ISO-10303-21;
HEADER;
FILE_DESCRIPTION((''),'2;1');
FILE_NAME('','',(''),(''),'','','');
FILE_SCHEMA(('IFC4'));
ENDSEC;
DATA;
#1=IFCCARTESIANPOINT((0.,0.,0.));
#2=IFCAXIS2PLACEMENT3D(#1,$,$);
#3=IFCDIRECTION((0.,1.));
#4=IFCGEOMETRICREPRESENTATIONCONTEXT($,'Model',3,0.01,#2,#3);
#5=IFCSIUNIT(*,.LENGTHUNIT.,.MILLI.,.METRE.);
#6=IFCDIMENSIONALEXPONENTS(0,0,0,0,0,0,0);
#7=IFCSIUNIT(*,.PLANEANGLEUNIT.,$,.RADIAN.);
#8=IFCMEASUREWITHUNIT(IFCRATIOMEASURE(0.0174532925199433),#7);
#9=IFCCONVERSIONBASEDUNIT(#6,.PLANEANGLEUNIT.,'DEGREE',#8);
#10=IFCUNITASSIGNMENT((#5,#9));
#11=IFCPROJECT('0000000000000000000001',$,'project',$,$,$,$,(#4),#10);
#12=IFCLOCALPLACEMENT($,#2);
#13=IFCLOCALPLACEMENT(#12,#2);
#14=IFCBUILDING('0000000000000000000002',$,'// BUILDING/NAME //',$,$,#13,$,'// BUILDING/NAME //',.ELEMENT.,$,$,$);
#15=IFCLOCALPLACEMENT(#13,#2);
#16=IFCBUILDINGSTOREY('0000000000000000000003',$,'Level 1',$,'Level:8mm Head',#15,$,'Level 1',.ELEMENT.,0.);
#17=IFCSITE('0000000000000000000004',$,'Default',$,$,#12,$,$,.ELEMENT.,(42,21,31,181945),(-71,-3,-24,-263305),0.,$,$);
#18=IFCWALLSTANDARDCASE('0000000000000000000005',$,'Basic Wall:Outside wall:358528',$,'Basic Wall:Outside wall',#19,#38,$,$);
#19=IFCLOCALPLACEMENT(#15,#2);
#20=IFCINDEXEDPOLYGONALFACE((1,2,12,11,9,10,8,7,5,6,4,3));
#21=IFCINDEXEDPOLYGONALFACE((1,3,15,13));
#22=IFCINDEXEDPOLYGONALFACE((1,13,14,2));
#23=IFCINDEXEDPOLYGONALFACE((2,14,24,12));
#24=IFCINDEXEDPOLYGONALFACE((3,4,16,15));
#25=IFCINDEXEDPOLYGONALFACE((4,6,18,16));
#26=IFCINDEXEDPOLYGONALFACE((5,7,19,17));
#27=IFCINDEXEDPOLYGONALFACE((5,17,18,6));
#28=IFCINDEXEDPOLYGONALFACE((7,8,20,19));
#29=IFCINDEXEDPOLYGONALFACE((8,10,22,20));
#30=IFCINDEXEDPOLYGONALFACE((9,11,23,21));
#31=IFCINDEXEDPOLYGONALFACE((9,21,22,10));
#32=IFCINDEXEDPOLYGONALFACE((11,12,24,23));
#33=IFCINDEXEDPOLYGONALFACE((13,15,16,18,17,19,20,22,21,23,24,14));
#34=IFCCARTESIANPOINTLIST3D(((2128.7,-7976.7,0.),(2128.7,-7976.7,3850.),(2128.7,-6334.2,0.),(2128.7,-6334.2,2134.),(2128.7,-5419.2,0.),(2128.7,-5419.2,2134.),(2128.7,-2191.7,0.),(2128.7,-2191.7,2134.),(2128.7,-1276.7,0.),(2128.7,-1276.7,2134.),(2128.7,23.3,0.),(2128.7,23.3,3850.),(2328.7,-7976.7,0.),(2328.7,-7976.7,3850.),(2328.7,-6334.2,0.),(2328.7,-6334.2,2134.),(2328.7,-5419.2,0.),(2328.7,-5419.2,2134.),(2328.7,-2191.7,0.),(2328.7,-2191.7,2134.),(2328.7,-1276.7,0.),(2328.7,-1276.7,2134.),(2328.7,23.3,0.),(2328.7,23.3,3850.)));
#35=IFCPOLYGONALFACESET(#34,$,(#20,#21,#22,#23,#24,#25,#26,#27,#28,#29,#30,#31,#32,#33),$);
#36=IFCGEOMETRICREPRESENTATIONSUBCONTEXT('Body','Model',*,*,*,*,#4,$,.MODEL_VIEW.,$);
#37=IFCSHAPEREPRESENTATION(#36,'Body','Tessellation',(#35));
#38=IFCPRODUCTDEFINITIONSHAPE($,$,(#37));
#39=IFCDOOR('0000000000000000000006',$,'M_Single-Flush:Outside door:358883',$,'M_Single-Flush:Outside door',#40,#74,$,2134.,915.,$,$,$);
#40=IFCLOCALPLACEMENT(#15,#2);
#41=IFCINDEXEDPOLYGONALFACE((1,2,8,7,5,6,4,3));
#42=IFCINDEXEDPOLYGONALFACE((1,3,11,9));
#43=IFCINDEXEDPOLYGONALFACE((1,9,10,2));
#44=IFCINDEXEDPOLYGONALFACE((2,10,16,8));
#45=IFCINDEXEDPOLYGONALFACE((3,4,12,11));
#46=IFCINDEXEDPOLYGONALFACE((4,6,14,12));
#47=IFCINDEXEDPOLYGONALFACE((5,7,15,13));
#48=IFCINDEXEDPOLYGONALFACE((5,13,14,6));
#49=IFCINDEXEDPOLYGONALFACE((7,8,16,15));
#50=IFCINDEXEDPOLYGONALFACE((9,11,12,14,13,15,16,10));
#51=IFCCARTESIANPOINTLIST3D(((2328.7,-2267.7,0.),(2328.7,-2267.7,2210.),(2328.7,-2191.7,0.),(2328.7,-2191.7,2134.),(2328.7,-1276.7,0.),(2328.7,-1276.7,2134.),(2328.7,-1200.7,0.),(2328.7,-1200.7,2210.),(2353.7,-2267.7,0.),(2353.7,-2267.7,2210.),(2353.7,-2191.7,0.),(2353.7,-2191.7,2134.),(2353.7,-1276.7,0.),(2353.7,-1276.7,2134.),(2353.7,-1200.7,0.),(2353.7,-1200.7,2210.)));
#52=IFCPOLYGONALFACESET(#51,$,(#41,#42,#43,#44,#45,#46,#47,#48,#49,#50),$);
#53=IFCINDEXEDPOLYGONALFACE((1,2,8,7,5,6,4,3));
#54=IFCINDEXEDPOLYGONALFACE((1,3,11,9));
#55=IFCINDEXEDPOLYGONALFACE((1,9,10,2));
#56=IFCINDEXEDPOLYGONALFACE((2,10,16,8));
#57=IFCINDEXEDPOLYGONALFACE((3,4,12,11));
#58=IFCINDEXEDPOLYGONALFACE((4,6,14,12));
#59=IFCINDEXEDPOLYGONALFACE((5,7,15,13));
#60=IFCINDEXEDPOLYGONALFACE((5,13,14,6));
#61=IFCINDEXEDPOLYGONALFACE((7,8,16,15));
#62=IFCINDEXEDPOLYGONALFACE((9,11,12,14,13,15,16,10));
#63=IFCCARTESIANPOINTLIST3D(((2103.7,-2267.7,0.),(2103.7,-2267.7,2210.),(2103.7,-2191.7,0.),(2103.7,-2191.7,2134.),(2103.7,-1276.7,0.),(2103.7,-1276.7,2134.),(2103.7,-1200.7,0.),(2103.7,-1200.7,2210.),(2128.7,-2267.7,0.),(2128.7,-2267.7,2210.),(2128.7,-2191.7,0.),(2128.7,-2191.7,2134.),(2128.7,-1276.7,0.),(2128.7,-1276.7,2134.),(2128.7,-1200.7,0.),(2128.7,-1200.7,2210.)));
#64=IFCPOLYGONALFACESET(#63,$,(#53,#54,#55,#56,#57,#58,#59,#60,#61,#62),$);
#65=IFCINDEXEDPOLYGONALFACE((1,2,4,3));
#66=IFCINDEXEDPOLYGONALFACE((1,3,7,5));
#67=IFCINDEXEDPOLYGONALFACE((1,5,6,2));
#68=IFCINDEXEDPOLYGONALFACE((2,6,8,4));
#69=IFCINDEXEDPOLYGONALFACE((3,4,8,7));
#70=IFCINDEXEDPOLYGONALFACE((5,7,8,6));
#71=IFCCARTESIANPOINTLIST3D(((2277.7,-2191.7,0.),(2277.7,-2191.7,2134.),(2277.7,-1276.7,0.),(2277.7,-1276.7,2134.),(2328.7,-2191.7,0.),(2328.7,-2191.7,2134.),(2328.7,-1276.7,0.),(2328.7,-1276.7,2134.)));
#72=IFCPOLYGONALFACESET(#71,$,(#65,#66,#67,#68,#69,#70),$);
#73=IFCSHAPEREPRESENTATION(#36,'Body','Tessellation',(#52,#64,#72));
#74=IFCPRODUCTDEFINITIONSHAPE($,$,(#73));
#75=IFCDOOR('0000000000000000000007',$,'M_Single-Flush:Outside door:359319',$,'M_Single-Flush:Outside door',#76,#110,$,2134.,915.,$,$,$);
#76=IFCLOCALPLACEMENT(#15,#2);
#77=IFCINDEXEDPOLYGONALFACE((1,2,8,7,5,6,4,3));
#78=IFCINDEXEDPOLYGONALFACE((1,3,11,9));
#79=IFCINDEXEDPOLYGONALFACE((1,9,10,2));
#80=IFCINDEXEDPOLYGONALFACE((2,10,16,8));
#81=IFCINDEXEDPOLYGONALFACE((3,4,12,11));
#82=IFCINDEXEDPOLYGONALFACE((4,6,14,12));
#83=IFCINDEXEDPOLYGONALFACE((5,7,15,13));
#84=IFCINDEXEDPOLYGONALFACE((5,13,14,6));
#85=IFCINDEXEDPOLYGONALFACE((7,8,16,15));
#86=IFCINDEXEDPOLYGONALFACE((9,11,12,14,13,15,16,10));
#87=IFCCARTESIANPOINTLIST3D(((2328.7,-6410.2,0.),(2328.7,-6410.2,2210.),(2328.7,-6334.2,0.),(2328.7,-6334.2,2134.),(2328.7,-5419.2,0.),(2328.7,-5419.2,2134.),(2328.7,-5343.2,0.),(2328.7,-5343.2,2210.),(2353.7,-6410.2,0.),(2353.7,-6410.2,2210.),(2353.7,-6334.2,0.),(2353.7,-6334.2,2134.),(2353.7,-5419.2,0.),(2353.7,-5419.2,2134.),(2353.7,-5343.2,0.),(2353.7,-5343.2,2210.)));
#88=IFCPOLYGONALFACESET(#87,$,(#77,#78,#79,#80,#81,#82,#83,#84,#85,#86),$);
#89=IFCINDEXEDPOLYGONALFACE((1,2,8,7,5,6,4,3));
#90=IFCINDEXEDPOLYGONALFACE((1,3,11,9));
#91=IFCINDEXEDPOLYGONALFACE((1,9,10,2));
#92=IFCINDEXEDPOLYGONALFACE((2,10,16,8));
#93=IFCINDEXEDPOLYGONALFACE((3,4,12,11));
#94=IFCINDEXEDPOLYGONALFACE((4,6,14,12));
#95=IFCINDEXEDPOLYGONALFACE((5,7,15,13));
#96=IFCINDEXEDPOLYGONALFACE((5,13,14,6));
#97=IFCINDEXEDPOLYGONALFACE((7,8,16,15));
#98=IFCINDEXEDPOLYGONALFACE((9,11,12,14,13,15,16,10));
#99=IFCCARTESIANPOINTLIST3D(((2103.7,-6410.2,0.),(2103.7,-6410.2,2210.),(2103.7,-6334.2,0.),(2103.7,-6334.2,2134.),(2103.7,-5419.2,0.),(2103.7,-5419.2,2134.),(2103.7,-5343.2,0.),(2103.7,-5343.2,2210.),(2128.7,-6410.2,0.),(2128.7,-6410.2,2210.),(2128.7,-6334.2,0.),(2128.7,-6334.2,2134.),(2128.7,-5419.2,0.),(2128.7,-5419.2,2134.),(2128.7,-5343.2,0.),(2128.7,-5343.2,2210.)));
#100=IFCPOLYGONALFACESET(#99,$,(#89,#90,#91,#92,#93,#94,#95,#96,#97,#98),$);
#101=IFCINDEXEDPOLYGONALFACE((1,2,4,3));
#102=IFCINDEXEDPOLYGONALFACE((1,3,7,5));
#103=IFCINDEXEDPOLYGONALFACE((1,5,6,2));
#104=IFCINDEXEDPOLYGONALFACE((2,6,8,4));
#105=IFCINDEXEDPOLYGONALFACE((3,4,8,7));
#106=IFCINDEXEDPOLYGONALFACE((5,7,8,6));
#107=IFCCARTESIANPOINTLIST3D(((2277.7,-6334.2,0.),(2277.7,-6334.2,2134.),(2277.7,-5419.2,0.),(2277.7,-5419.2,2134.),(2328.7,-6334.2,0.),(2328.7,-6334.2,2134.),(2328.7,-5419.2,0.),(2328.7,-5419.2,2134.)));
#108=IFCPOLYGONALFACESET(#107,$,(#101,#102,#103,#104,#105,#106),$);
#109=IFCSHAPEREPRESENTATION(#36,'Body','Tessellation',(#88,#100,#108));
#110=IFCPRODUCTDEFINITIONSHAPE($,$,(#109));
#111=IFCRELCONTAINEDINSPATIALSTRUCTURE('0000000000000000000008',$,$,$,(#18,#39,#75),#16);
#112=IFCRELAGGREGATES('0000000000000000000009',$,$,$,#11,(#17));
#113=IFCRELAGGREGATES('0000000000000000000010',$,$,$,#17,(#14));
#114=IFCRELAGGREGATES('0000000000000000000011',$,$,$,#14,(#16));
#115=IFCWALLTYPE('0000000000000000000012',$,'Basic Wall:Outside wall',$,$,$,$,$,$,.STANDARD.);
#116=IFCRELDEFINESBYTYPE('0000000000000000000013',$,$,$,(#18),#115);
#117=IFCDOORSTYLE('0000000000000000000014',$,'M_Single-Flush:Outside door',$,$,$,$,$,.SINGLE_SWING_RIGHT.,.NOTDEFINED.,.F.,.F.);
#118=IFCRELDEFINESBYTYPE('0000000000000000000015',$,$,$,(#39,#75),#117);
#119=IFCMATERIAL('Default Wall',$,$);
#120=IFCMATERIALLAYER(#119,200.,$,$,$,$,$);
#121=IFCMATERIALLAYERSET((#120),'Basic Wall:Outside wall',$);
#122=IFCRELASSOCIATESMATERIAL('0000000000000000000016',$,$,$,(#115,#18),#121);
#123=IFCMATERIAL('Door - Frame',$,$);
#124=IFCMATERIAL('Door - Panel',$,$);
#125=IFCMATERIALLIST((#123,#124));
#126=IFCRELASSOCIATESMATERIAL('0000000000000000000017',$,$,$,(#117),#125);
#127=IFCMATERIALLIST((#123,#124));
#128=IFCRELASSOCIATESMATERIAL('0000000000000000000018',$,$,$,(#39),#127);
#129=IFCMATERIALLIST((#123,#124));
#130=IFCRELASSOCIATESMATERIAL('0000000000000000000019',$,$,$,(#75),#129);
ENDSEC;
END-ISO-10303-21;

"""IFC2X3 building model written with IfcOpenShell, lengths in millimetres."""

from ifc_helpers import new_model, entity, si_unit, converted_unit, direction, frame, frame_2d, origin, place, context, subcontext, project, spatial, polyline, rectangle, outline, extrude, clip, halfspace, bounded_halfspace, source, transform, mapped, material, material_list, layer, layer_set, layer_usage, type_object, type_shapes, element, fill, save


model = new_model("IFC2X3")

# Units and contexts
model_context = context("Model", 3, precision=0.01, world=origin(), true_north=direction((0.0, 1.0)))
body_context = subcontext(model_context, "Body", "Model", "MODEL_VIEW")
ifc_project = project(units=[si_unit("LENGTHUNIT", "METRE", prefix="MILLI"), converted_unit("PLANEANGLEUNIT", "DEGREE", entity("IfcRatioMeasure", 0.0174532925199433), si_unit("PLANEANGLEUNIT", "RADIAN"), dimensions=[0, 0, 0, 0, 0, 0, 0])], contexts=[model_context])

# Site, building, storey
site_placement = place(None, origin())
site = spatial("IfcSite", under=ifc_project, at=site_placement, Name="Default", CompositionType="ELEMENT", RefLatitude=(42, 21, 31, 181945), RefLongitude=(-71, -3, -24, -263305), RefElevation=0.0)
building_placement = place(site_placement, origin())
building = spatial("IfcBuilding", under=site, at=building_placement, Name="// BUILDING/NAME //", LongName="// BUILDING/NAME //", CompositionType="ELEMENT")
storey_placement = place(building_placement, origin())
storey = spatial("IfcBuildingStorey", under=building, at=storey_placement, Name="Level 1", ObjectType="Level:8mm Head", LongName="Level 1", CompositionType="ELEMENT", Elevation=0.0)

# Shared definitions
ifc_material_1 = material(Name="Default Wall")
ifc_layer_1 = layer(ifc_material_1, 200.0)
ifc_layer_set_1 = layer_set([ifc_layer_1], Name="Basic Wall:Outside wall")
wall_type_1 = type_object("IfcWallType", Name="Basic Wall:Outside wall", PredefinedType="STANDARD", material=ifc_layer_set_1)

# Wall, openings, doors
ifc_layer_usage_1 = layer_usage(ifc_layer_set_1, "AXIS2", "NEGATIVE", 100.0)
wall_1_placement = place(storey_placement, frame((2228.7, 23.3, 0.0), z_axis=(0.0, 0.0, 1.0), x_axis=(0.0, -1.0, 0.0)))
wall_1 = element("IfcWallStandardCase", 1, at=wall_1_placement, inside=storey, type_object=wall_type_1, material=ifc_layer_usage_1, Name="Basic Wall:Outside wall:358528", ObjectType="Basic Wall:Outside wall", context=body_context, shape_type="Clipping", body=[
    clip(clip(extrude(rectangle(XDim=8000.0, YDim=200.0, at=frame_2d((4000.0, 0.0), x_axis=(-1.0, 0.0))), origin(), (0.0, 0.0, 1.0), 3850.0), bounded_halfspace(frame((0.0, -100.0, 3850.0), z_axis=(0.0, 0.0, -1.0), x_axis=(1.0, 0.0, 0.0)), True, frame((0.0, -100.0, 3850.0), z_axis=(0.0, 0.0, -1.0), x_axis=(1.0, 0.0, 0.0)), polyline([(0.0, 0.0), (0.0, -200.0), (8000.0, -200.0), (8000.0, 0.0), (7800.0, 0.0), (0.0, 0.0)]))), halfspace(origin(), True)),
])
opening_1_placement = place(wall_1_placement, frame((1300.0, -100.0, 0.0)))
opening_1 = element("IfcOpeningElement", 2, at=opening_1_placement, cuts=wall_1, ObjectType="Opening", context=body_context, shape_type="SweptSolid", body=[
    extrude(rectangle(XDim=915.0, YDim=2134.0, at=frame_2d((1067.0, 457.5), x_axis=(0.0, 1.0))), frame((0.0, 0.0, 0.0), z_axis=(0.0, 1.0, 0.0), x_axis=(0.0, 0.0, 1.0)), (0.0, 0.0, 1.0), 200.0),
])
opening_2_placement = place(wall_1_placement, frame((5442.5, -100.0, 0.0)))
opening_2 = element("IfcOpeningElement", 3, at=opening_2_placement, cuts=wall_1, ObjectType="Opening", context=body_context, shape_type="SweptSolid", body=[
    extrude(rectangle(XDim=915.0, YDim=2134.0, at=frame_2d((1067.0, 457.5), x_axis=(0.0, 1.0))), frame((0.0, 0.0, 0.0), z_axis=(0.0, 1.0, 0.0), x_axis=(0.0, 0.0, 1.0)), (0.0, 0.0, 1.0), 200.0),
])
ifc_material_2 = material(Name="Door - Frame")
ifc_material_3 = material(Name="Door - Panel")
ifc_material_list_1 = material_list([ifc_material_2, ifc_material_3])
ifc_material_list_2 = material_list([ifc_material_2, ifc_material_3])
door_style_1 = type_object("IfcDoorStyle", Name="M_Single-Flush:Outside door", ConstructionType="NOTDEFINED", OperationType="SINGLE_SWING_RIGHT", ParameterTakesPrecedence=False, Sizeable=False, material=ifc_material_list_2)
shared_shape_1 = source(origin(), body_context, "Body", "SweptSolid", [
    extrude(outline(polyline([(-533.5, -1124.0), (533.5, -1124.0), (533.5, 1086.0), (457.5, 1086.0), (457.5, -1048.0), (-457.5, -1048.0), (-457.5, 1086.0), (-533.5, 1086.0), (-533.5, -1124.0)])), frame((457.5, 200.0, 1086.0), z_axis=(0.0, 1.0, 0.0), x_axis=(1.0, 0.0, 0.0)), (0.0, 0.0, 1.0), 25.0),
    extrude(outline(polyline([(-1124.0, -533.5), (1086.0, -533.5), (1086.0, -457.5), (-1048.0, -457.5), (-1048.0, 457.5), (1086.0, 457.5), (1086.0, 533.5), (-1124.0, 533.5), (-1124.0, -533.5)])), frame((457.5, -25.0, 1086.0), z_axis=(0.0, 1.0, 0.0), x_axis=(0.0, 0.0, -1.0)), (0.0, 0.0, 1.0), 25.0),
    extrude(rectangle(XDim=51.0, YDim=915.0, at=frame_2d((0.0, 0.0), x_axis=(1.0, 0.0))), frame((457.5, 174.5, 0.0), z_axis=(0.0, 0.0, 1.0), x_axis=(0.0, 1.0, 0.0)), (0.0, 0.0, 1.0), 2134.0),
])
type_shapes(door_style_1, [shared_shape_1])
door_1_placement = place(opening_1_placement, origin())
door_1 = element("IfcDoor", 4, at=door_1_placement, inside=storey, type_object=door_style_1, material=ifc_material_list_1, Name="M_Single-Flush:Outside door:358883", ObjectType="M_Single-Flush:Outside door", OverallHeight=2134.0, OverallWidth=915.0, context=body_context, shape_type="MappedRepresentation", body=[
    mapped(shared_shape_1, transform((0.0, 0.0, 0.0), scale=1.0)),
])
fill(opening_1, door_1)
ifc_material_list_3 = material_list([ifc_material_2, ifc_material_3])
door_2_placement = place(opening_2_placement, origin())
door_2 = element("IfcDoor", 5, at=door_2_placement, inside=storey, type_object=door_style_1, material=ifc_material_list_3, Name="M_Single-Flush:Outside door:359319", ObjectType="M_Single-Flush:Outside door", OverallHeight=2134.0, OverallWidth=915.0, context=body_context, shape_type="MappedRepresentation", body=[
    mapped(shared_shape_1, transform((0.0, 0.0, 0.0), scale=1.0)),
])
fill(opening_2, door_2)

save(model, "model.ifc")
